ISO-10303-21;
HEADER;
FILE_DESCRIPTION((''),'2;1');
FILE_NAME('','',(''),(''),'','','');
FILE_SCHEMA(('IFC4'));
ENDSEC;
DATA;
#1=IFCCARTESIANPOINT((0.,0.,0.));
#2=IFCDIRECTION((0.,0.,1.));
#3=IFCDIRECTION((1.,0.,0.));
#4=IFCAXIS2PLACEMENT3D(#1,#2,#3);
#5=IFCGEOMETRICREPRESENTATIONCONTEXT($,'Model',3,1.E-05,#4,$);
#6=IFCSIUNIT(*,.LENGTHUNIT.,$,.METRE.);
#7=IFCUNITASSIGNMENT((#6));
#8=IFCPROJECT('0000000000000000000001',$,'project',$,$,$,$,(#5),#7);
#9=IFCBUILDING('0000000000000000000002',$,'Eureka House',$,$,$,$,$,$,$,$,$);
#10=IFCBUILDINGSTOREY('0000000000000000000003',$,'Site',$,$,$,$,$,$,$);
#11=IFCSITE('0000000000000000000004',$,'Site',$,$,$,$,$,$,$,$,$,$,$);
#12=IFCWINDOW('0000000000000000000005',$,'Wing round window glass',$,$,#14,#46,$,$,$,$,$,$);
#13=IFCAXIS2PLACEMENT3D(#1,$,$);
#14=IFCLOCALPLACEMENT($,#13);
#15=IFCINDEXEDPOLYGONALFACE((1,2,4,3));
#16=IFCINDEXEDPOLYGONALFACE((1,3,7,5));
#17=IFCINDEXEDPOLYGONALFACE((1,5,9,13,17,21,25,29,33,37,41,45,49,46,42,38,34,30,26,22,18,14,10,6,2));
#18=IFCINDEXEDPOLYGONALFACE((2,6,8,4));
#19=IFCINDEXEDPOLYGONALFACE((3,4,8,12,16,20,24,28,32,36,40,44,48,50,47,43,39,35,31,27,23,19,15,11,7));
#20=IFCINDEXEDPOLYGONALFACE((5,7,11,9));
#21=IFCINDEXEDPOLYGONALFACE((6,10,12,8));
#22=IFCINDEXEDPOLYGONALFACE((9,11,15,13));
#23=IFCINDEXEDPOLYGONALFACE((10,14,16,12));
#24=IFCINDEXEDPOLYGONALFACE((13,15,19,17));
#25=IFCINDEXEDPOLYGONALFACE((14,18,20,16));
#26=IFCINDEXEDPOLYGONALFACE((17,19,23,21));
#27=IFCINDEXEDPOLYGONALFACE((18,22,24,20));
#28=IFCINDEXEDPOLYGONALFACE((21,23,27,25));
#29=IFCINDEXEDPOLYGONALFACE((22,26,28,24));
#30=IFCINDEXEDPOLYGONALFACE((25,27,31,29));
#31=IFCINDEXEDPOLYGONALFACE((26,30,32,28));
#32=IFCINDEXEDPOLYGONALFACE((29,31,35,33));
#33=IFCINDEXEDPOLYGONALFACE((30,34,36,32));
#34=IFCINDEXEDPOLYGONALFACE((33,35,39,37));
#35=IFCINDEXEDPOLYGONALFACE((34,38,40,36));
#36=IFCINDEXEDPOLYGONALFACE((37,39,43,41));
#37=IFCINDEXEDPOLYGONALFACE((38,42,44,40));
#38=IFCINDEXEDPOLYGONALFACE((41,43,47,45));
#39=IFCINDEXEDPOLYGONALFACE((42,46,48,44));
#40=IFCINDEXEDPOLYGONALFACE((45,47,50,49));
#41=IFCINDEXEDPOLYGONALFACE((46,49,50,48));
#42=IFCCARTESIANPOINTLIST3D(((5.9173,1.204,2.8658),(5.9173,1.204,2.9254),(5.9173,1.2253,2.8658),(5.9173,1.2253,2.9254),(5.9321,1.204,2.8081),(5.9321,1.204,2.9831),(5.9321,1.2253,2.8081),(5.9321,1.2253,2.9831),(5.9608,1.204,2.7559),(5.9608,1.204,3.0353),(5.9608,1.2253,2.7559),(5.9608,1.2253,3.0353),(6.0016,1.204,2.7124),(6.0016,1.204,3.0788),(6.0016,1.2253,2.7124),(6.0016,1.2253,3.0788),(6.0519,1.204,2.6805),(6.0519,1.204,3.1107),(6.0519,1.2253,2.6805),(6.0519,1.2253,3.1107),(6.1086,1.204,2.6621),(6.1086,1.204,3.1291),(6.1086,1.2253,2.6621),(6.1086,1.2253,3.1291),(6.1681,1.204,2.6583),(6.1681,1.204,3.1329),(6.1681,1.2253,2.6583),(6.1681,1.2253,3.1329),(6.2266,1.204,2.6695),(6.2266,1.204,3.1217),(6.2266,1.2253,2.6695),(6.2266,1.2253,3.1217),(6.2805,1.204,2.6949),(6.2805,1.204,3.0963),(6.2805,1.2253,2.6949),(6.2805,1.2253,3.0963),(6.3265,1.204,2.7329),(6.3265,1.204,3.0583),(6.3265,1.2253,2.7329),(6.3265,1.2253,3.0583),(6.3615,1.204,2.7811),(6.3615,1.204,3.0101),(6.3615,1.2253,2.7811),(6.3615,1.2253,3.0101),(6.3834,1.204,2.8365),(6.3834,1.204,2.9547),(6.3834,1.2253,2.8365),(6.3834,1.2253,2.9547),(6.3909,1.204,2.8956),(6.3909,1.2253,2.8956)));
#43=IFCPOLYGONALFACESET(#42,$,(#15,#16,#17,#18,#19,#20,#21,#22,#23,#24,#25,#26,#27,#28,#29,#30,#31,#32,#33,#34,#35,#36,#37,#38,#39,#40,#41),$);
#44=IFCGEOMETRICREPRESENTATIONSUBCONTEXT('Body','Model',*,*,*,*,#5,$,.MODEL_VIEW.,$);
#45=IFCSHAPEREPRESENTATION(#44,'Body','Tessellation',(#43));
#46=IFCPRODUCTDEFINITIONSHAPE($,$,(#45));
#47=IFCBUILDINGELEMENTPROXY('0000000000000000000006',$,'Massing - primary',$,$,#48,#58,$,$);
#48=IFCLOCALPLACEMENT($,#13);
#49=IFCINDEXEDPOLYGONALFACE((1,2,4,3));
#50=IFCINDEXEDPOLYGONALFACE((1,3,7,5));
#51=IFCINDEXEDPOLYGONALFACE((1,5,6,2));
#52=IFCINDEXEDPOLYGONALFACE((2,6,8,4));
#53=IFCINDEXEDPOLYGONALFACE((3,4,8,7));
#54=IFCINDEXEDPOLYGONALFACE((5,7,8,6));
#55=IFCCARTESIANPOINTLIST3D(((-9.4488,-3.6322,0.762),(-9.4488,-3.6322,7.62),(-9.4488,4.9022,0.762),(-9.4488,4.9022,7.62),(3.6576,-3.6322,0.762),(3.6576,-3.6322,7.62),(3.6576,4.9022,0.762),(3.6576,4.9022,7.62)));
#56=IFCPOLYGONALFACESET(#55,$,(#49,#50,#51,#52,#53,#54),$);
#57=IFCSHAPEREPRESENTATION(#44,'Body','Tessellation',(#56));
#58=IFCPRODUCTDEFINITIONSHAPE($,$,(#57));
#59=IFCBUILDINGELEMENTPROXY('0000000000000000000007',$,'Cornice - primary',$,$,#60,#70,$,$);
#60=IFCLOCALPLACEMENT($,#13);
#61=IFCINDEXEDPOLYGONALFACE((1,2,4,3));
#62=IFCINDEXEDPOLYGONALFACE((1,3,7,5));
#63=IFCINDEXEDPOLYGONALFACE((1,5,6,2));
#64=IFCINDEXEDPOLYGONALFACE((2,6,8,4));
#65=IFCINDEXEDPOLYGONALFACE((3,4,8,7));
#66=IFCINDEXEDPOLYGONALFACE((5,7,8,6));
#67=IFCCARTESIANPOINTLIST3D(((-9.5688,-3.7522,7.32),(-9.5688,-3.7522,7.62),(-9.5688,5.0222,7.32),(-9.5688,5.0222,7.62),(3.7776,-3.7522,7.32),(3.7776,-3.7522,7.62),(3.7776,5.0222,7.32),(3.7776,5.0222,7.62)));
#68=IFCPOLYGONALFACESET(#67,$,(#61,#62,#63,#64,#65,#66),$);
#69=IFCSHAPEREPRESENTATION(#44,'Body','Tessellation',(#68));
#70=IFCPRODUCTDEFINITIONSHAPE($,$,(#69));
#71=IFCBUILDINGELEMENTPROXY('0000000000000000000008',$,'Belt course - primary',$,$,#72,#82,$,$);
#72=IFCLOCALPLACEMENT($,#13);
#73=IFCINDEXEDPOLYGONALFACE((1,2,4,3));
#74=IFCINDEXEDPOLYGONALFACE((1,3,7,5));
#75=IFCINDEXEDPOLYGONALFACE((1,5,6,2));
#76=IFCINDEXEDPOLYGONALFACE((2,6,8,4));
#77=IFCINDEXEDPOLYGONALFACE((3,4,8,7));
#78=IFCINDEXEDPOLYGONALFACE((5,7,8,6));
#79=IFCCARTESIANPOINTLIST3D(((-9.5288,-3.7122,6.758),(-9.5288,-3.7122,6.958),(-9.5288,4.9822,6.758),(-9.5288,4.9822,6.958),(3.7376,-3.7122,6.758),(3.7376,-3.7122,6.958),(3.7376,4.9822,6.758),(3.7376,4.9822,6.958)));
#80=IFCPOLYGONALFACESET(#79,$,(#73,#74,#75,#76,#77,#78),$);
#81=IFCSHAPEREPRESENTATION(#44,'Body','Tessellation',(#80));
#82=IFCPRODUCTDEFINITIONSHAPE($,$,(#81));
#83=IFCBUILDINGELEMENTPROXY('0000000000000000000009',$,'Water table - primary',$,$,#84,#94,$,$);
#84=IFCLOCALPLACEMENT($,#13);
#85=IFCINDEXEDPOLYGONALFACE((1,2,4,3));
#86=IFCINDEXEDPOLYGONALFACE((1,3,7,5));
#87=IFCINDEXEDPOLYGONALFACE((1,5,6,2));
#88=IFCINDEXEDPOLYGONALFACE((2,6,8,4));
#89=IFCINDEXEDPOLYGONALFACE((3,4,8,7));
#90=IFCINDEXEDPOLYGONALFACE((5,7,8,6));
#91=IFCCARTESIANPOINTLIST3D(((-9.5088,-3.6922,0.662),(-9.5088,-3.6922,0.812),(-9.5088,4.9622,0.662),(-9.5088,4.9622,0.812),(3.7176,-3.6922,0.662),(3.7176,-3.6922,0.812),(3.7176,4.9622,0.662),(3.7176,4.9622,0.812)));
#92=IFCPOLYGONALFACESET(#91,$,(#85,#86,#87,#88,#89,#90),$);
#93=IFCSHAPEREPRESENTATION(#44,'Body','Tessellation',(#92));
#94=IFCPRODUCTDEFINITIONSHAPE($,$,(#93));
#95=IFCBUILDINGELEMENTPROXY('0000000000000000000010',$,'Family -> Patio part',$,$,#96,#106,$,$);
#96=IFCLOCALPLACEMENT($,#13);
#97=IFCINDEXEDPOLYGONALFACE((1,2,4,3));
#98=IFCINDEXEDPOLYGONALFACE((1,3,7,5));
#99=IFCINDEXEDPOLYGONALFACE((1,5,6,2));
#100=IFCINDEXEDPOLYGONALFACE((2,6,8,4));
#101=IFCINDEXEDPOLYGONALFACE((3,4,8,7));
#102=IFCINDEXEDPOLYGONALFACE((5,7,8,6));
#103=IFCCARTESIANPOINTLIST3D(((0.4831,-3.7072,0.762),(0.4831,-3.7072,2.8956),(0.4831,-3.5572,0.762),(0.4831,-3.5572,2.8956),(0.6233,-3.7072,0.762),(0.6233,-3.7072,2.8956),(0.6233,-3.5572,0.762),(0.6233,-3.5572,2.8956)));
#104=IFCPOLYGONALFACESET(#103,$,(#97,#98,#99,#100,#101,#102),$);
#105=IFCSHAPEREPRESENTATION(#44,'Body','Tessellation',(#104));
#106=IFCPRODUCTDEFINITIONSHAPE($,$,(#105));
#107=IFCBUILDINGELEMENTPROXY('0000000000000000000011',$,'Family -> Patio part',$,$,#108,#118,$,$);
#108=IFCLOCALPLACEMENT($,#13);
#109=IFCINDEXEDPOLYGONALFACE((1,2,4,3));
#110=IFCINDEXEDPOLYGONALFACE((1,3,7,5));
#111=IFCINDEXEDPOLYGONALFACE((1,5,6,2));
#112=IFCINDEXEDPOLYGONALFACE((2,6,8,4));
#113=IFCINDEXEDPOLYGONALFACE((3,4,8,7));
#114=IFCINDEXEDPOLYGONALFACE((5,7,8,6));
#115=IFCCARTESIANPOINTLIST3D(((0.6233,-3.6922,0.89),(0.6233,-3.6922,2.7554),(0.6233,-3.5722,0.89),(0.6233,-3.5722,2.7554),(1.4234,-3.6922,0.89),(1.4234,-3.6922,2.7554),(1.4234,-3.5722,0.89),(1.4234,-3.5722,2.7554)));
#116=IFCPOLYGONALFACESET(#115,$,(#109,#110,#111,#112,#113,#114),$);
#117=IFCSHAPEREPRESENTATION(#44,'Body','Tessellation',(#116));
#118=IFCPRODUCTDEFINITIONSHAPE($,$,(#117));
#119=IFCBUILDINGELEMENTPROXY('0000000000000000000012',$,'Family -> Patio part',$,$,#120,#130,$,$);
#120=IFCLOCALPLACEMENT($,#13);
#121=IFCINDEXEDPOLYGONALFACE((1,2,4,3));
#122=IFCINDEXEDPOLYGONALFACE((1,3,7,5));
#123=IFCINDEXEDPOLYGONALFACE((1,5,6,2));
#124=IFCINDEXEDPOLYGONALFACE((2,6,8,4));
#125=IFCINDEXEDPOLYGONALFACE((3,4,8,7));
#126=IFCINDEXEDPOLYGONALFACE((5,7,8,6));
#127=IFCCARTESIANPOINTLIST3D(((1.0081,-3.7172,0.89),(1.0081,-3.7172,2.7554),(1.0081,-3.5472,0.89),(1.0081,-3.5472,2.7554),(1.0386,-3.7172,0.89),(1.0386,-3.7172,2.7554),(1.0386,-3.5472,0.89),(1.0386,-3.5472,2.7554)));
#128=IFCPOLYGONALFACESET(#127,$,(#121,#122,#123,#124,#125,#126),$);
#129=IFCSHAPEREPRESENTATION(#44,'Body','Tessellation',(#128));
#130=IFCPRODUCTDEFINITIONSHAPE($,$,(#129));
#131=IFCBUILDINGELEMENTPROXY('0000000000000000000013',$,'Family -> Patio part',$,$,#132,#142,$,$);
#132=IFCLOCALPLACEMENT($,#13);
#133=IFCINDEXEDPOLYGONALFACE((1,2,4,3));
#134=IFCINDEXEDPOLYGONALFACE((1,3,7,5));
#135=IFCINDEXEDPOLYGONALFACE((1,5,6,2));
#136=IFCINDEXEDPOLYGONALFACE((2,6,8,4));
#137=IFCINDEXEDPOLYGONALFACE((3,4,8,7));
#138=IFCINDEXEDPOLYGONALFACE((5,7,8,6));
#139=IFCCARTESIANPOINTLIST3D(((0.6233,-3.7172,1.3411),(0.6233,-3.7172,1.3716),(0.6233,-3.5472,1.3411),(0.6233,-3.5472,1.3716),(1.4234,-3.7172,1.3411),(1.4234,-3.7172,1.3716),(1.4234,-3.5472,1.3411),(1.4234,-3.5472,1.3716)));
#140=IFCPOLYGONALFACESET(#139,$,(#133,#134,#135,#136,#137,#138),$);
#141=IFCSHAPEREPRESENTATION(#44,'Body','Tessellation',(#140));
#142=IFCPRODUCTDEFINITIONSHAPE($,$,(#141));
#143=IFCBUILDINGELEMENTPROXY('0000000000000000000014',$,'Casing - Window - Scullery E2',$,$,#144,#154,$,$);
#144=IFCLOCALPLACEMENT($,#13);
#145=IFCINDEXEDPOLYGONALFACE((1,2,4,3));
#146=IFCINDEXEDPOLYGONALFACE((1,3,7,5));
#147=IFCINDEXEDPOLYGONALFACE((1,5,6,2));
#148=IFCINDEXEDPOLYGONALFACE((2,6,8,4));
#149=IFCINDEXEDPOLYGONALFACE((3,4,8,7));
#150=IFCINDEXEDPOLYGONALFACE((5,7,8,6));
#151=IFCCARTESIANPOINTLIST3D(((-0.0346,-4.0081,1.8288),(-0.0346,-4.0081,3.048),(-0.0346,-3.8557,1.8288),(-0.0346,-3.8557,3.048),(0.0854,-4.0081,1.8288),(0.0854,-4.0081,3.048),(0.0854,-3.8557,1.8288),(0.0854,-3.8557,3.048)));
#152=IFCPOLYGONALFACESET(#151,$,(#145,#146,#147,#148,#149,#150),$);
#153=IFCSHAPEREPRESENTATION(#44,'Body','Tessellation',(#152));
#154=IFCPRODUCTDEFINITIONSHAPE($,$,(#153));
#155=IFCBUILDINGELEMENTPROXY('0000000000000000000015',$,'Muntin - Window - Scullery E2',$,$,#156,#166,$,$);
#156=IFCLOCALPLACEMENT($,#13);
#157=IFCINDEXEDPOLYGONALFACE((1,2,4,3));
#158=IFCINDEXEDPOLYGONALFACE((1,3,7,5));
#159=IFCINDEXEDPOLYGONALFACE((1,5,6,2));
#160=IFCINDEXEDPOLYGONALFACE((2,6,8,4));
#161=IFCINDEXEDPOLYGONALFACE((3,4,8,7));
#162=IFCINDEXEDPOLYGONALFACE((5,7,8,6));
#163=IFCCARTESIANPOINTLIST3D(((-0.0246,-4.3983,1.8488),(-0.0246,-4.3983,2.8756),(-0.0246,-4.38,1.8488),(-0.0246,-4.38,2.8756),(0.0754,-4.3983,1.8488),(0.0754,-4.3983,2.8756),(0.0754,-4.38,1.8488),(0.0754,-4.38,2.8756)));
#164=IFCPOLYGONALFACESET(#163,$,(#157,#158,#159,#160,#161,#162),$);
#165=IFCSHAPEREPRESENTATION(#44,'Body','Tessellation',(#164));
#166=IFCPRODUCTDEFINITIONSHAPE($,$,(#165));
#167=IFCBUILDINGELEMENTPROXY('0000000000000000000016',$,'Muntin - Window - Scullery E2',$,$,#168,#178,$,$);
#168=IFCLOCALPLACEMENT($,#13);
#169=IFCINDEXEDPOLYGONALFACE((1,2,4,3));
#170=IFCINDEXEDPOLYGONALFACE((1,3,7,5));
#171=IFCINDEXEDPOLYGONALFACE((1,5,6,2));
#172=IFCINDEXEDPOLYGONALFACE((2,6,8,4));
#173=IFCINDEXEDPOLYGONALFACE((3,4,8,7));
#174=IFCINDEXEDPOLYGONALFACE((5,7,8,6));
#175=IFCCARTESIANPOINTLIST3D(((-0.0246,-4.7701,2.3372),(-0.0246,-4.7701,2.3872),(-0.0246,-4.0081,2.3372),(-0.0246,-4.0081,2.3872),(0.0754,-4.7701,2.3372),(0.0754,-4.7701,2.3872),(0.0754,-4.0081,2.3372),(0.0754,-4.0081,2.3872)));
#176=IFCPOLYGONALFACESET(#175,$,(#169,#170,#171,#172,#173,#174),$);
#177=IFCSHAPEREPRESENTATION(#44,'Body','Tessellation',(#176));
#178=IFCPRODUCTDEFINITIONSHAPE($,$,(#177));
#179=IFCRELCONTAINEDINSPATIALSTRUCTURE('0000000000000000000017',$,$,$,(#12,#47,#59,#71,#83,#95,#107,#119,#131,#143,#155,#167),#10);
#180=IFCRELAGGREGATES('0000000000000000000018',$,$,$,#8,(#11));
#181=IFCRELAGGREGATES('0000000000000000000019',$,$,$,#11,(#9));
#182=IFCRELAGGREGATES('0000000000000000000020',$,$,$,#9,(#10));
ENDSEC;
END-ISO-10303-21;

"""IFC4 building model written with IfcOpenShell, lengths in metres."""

from ifc_helpers import new_model, si_unit, frame, origin, origin_with_axes, origin_2d, place, context, subcontext, project, spatial, rectangle, circle, extrude, element, save


model = new_model("IFC4")

# Units and contexts
model_context = context("Model", 3, precision=1e-05, world=origin_with_axes())
body_context = subcontext(model_context, "Body", "Model", "MODEL_VIEW")
ifc_project = project(units=[si_unit("LENGTHUNIT", "METRE")], contexts=[model_context])

# Site, building, storey
site = spatial("IfcSite", under=ifc_project, Name="Site")
building = spatial("IfcBuilding", under=site, Name="Eureka House")
storey = spatial("IfcBuildingStorey", under=building, Name="Site")

# Window
window_1_placement = place(None, origin_with_axes())
element("IfcWindow", 1, at=window_1_placement, inside=storey, Name="Wing round window glass", context=body_context, shape_type="SweptSolid", body=[
    extrude(circle(Radius=0.2377), frame((6.1532, 1.204, 2.8956), z_axis=(0.0, 1.0, 0.0), x_axis=(1.0, 0.0, 0.0)), (0.0, 0.0, 1.0), 0.0213),
])

# Building element proxies
proxy_1_placement = place(None, frame((-2.8956, 0.635, 0.762), z_axis=(0.0, 0.0, 1.0), x_axis=(1.0, 0.0, 0.0)))
element("IfcBuildingElementProxy", 2, at=proxy_1_placement, inside=storey, Name="Massing - primary", context=body_context, shape_type="SweptSolid", body=[
    extrude(rectangle(XDim=13.1064, YDim=8.5344, at=origin_2d()), origin(), (0.0, 0.0, 1.0), 6.858),
])
proxy_2_placement = place(None, frame((-2.8956, 0.635, 7.32), z_axis=(0.0, 0.0, 1.0), x_axis=(1.0, 0.0, 0.0)))
element("IfcBuildingElementProxy", 3, at=proxy_2_placement, inside=storey, Name="Cornice - primary", context=body_context, shape_type="SweptSolid", body=[
    extrude(rectangle(XDim=13.3464, YDim=8.7744, at=origin_2d()), origin(), (0.0, 0.0, 1.0), 0.3),
])
proxy_3_placement = place(None, frame((-2.8956, 0.635, 6.758), z_axis=(0.0, 0.0, 1.0), x_axis=(1.0, 0.0, 0.0)))
element("IfcBuildingElementProxy", 4, at=proxy_3_placement, inside=storey, Name="Belt course - primary", context=body_context, shape_type="SweptSolid", body=[
    extrude(rectangle(XDim=13.2664, YDim=8.6944, at=origin_2d()), origin(), (0.0, 0.0, 1.0), 0.2),
])
proxy_4_placement = place(None, frame((-2.8956, 0.635, 0.662), z_axis=(0.0, 0.0, 1.0), x_axis=(1.0, 0.0, 0.0)))
element("IfcBuildingElementProxy", 5, at=proxy_4_placement, inside=storey, Name="Water table - primary", context=body_context, shape_type="SweptSolid", body=[
    extrude(rectangle(XDim=13.2264, YDim=8.6544, at=origin_2d()), origin(), (0.0, 0.0, 1.0), 0.15),
])
proxy_5_placement = place(None, frame((0.5532, -3.6322, 0.762), z_axis=(0.0, 0.0, 1.0), x_axis=(1.0, 0.0, 0.0)))
element("IfcBuildingElementProxy", 6, at=proxy_5_placement, inside=storey, Name="Family -> Patio part", context=body_context, shape_type="SweptSolid", body=[
    extrude(rectangle(XDim=0.1402, YDim=0.15, at=origin_2d()), origin(), (0.0, 0.0, 1.0), 2.1336),
])
proxy_6_placement = place(None, frame((1.0234, -3.6322, 0.89), z_axis=(0.0, 0.0, 1.0), x_axis=(1.0, 0.0, 0.0)))
element("IfcBuildingElementProxy", 7, at=proxy_6_placement, inside=storey, Name="Family -> Patio part", context=body_context, shape_type="SweptSolid", body=[
    extrude(rectangle(XDim=0.8001, YDim=0.12, at=origin_2d()), origin(), (0.0, 0.0, 1.0), 1.8654),
])
proxy_7_placement = place(None, frame((1.0234, -3.6322, 0.89), z_axis=(0.0, 0.0, 1.0), x_axis=(1.0, 0.0, 0.0)))
element("IfcBuildingElementProxy", 8, at=proxy_7_placement, inside=storey, Name="Family -> Patio part", context=body_context, shape_type="SweptSolid", body=[
    extrude(rectangle(XDim=0.0305, YDim=0.17, at=origin_2d()), origin(), (0.0, 0.0, 1.0), 1.8654),
])
proxy_8_placement = place(None, frame((1.0234, -3.6322, 1.3411), z_axis=(0.0, 0.0, 1.0), x_axis=(1.0, 0.0, 0.0)))
element("IfcBuildingElementProxy", 9, at=proxy_8_placement, inside=storey, Name="Family -> Patio part", context=body_context, shape_type="SweptSolid", body=[
    extrude(rectangle(XDim=0.8001, YDim=0.17, at=origin_2d()), origin(), (0.0, 0.0, 1.0), 0.0305),
])
proxy_9_placement = place(None, frame((0.0254, -3.9319, 1.8288), z_axis=(0.0, 0.0, 1.0), x_axis=(1.0, 0.0, 0.0)))
element("IfcBuildingElementProxy", 10, at=proxy_9_placement, inside=storey, Name="Casing - Window - Scullery E2", context=body_context, shape_type="SweptSolid", body=[
    extrude(rectangle(XDim=0.12, YDim=0.1524, at=origin_2d()), origin(), (0.0, 0.0, 1.0), 1.2192),
])
proxy_10_placement = place(None, frame((0.0254, -4.3891, 1.8488), z_axis=(0.0, 0.0, 1.0), x_axis=(1.0, 0.0, 0.0)))
element("IfcBuildingElementProxy", 11, at=proxy_10_placement, inside=storey, Name="Muntin - Window - Scullery E2", context=body_context, shape_type="SweptSolid", body=[
    extrude(rectangle(XDim=0.1, YDim=0.0183, at=origin_2d()), origin(), (0.0, 0.0, 1.0), 1.0268),
])
proxy_11_placement = place(None, frame((0.0254, -4.3891, 2.3372), z_axis=(0.0, 0.0, 1.0), x_axis=(1.0, 0.0, 0.0)))
element("IfcBuildingElementProxy", 12, at=proxy_11_placement, inside=storey, Name="Muntin - Window - Scullery E2", context=body_context, shape_type="SweptSolid", body=[
    extrude(rectangle(XDim=0.1, YDim=0.762, at=origin_2d()), origin(), (0.0, 0.0, 1.0), 0.05),
])

save(model, "model.ifc")
